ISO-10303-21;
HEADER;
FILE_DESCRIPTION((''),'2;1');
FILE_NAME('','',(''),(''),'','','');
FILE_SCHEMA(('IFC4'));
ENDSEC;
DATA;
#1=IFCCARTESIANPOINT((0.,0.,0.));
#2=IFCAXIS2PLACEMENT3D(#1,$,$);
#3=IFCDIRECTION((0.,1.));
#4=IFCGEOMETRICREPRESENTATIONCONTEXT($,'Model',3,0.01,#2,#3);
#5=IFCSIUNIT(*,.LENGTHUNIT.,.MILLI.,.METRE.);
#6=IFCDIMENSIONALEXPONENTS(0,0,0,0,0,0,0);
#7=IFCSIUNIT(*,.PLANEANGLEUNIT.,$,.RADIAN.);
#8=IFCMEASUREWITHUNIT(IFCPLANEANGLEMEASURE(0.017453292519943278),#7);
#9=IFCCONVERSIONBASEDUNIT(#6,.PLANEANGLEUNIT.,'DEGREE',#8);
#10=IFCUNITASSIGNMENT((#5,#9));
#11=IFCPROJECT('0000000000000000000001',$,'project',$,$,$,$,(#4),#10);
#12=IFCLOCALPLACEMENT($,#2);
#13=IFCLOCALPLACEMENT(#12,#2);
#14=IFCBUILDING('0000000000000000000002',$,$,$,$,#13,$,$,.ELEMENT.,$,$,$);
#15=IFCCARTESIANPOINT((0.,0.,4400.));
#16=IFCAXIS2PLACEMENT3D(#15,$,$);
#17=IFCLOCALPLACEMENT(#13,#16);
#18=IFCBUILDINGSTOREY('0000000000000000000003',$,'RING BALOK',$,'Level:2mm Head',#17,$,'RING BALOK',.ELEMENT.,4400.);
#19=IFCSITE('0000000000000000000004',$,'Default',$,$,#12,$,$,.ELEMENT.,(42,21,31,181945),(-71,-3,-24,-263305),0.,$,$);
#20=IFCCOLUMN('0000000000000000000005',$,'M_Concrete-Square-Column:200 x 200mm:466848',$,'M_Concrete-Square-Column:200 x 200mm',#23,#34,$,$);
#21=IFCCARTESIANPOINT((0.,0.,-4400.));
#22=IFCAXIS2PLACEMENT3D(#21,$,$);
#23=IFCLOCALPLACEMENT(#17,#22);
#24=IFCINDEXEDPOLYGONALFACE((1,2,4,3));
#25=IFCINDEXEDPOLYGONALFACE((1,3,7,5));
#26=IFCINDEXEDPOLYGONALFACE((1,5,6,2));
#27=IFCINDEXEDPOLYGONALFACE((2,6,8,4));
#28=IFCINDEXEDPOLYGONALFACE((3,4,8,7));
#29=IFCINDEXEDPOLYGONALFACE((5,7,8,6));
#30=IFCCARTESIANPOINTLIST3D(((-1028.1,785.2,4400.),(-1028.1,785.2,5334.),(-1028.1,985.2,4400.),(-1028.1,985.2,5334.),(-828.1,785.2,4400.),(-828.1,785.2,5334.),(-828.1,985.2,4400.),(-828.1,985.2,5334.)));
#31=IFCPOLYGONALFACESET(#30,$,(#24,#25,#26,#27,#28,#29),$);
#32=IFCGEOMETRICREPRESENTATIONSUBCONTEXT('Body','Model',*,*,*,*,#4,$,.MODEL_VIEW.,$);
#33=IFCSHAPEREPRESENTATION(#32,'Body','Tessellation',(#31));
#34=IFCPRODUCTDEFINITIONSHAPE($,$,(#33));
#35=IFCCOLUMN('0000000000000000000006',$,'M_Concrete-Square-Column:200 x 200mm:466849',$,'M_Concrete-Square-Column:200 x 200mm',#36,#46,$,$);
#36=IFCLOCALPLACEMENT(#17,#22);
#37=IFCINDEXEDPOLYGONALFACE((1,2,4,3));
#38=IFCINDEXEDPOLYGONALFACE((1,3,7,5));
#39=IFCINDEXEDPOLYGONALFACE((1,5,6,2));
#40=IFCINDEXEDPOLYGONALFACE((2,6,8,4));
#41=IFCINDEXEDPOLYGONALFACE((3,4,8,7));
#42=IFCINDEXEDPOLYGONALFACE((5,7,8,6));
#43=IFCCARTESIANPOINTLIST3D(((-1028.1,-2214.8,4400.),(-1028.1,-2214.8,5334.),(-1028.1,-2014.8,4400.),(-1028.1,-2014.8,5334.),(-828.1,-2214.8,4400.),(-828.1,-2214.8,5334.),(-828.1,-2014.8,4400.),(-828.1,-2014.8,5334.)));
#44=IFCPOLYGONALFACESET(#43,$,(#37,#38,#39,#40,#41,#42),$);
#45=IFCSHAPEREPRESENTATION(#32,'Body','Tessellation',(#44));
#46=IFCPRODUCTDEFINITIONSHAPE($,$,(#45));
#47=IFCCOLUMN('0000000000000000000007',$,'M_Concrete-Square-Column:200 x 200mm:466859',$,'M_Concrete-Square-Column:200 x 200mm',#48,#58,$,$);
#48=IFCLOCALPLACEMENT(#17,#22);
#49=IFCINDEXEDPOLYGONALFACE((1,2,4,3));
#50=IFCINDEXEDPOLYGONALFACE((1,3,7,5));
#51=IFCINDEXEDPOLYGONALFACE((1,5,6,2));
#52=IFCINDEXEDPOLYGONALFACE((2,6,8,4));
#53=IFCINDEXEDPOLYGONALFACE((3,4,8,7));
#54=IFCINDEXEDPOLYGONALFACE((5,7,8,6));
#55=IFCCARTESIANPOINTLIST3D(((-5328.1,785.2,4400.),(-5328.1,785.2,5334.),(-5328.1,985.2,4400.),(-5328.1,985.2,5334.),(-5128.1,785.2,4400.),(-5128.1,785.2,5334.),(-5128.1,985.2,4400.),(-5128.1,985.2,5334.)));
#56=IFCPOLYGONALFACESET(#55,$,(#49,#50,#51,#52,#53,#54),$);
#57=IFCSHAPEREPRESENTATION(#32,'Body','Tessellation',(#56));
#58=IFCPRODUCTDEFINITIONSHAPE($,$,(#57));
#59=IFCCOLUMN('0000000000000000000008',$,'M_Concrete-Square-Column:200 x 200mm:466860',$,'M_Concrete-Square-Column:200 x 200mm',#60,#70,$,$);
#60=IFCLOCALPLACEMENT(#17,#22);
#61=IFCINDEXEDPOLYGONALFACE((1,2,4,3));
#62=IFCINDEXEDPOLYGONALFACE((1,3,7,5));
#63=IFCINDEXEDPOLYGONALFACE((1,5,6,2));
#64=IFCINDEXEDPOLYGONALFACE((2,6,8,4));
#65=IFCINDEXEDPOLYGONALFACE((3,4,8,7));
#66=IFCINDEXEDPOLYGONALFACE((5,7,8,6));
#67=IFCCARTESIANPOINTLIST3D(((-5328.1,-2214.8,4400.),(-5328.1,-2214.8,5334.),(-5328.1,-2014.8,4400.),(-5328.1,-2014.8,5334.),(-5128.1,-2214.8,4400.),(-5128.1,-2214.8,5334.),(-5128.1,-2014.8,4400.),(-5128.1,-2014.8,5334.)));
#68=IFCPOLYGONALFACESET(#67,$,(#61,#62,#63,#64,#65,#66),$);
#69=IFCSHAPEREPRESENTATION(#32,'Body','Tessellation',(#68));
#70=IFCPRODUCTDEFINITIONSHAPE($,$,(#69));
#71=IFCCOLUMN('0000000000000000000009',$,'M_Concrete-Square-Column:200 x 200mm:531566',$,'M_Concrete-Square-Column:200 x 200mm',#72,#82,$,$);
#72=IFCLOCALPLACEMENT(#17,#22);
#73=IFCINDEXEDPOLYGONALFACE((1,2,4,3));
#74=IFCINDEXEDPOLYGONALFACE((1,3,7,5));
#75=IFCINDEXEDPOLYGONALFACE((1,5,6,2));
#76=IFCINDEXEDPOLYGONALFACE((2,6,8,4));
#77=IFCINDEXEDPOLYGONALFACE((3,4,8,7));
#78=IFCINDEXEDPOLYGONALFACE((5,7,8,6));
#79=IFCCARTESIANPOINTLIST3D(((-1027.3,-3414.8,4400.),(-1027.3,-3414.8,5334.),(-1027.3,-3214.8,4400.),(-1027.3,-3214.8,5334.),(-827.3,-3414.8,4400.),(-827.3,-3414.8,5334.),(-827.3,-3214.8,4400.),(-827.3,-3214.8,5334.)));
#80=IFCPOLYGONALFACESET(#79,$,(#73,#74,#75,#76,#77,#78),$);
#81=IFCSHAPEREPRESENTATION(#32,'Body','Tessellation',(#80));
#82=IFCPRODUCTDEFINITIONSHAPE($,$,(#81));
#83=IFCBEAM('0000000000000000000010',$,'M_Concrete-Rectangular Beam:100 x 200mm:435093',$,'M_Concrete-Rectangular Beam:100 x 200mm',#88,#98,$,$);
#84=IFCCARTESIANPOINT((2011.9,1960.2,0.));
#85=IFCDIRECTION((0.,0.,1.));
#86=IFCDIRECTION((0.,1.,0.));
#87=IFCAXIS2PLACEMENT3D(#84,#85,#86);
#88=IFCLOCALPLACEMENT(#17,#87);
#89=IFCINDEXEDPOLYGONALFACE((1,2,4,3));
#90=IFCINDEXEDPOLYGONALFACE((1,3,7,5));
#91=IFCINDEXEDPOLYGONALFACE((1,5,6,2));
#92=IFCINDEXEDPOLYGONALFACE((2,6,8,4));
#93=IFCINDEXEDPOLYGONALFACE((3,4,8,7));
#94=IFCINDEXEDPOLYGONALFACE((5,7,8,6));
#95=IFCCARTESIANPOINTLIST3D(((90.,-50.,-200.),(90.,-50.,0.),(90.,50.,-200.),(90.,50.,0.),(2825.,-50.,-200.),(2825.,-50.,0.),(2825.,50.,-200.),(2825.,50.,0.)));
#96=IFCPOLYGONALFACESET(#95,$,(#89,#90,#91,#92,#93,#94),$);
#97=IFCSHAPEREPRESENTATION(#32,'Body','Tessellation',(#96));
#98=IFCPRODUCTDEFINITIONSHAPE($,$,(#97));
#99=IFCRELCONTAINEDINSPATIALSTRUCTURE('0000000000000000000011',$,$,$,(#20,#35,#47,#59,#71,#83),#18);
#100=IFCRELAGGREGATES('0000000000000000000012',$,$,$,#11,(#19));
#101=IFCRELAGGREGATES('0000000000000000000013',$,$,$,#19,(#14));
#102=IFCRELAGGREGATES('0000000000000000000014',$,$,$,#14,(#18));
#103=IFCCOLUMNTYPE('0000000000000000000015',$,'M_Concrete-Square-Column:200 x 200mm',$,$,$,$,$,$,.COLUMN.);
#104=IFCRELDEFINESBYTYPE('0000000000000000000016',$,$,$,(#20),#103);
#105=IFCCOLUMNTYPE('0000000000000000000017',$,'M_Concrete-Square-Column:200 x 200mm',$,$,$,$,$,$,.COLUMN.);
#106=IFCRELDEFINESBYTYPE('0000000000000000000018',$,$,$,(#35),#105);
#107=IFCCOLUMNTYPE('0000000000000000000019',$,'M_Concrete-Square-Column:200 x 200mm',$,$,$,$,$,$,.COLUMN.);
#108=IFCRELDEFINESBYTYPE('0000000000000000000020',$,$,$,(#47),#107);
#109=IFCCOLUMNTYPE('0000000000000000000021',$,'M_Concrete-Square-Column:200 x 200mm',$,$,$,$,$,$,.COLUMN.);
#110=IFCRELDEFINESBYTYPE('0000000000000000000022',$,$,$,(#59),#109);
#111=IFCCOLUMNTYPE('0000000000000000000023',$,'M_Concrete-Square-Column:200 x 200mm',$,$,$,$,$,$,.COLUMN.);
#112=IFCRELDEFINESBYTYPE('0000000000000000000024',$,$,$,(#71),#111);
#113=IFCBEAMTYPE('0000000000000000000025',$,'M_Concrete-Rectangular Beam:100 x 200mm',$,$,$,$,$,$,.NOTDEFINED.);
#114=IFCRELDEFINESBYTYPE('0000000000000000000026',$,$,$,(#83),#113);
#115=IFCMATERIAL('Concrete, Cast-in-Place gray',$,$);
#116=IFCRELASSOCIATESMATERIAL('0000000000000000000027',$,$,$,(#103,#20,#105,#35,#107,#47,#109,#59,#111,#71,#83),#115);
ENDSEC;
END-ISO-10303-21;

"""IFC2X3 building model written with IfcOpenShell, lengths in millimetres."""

from ifc_helpers import new_model, entity, si_unit, converted_unit, direction, frame, frame_2d, origin, origin_2d_with_axis, place, context, subcontext, project, spatial, rectangle, extrude, source, transform, mapped, material, type_object, type_shapes, element, save


model = new_model("IFC2X3")

# Units and contexts
model_context = context("Model", 3, precision=0.01, world=origin(), true_north=direction((0.0, 1.0)))
body_context = subcontext(model_context, "Body", "Model", "MODEL_VIEW")
ifc_project = project(units=[si_unit("LENGTHUNIT", "METRE", prefix="MILLI"), converted_unit("PLANEANGLEUNIT", "DEGREE", entity("IfcPlaneAngleMeasure", 0.017453292519943278), si_unit("PLANEANGLEUNIT", "RADIAN"), dimensions=[0, 0, 0, 0, 0, 0, 0])], contexts=[model_context])

# Site, building, storey
site_placement = place(None, origin())
site = spatial("IfcSite", under=ifc_project, at=site_placement, Name="Default", CompositionType="ELEMENT", RefLatitude=(42, 21, 31, 181945), RefLongitude=(-71, -3, -24, -263305), RefElevation=0.0)
building_placement = place(site_placement, origin())
building = spatial("IfcBuilding", under=site, at=building_placement, CompositionType="ELEMENT")
storey_placement = place(building_placement, frame((0.0, 0.0, 4400.0)))
storey = spatial("IfcBuildingStorey", under=building, at=storey_placement, Name="RING BALOK", ObjectType="Level:2mm Head", LongName="RING BALOK", CompositionType="ELEMENT", Elevation=4400.0)

# Columns
ifc_material = material(Name="Concrete, Cast-in-Place gray")
column_type_1 = type_object("IfcColumnType", Name="M_Concrete-Square-Column:200 x 200mm", PredefinedType="COLUMN", material=ifc_material)
shared_shape_1 = source(origin(), body_context, "Body", "SweptSolid", [
    extrude(rectangle(XDim=200.0, YDim=200.0, at=origin_2d_with_axis()), frame((-928.1, 885.2, 4400.0), z_axis=(0.0, 0.0, 1.0), x_axis=(-1.0, 0.0, 0.0)), (0.0, 0.0, 1.0), 934.0),
])
type_shapes(column_type_1, [shared_shape_1])
column_1_placement = place(storey_placement, frame((0.0, 0.0, -4400.0)))
element("IfcColumn", 1, at=column_1_placement, inside=storey, type_object=column_type_1, material=ifc_material, Name="M_Concrete-Square-Column:200 x 200mm:466848", ObjectType="M_Concrete-Square-Column:200 x 200mm", context=body_context, shape_type="MappedRepresentation", body=[
    mapped(shared_shape_1, transform((0.0, 0.0, 0.0), scale=1.0)),
])
column_type_2 = type_object("IfcColumnType", Name="M_Concrete-Square-Column:200 x 200mm", PredefinedType="COLUMN", material=ifc_material)
shared_shape_2 = source(origin(), body_context, "Body", "SweptSolid", [
    extrude(rectangle(XDim=200.0, YDim=200.0, at=origin_2d_with_axis()), frame((-928.1, -2114.8, 4400.0), z_axis=(0.0, 0.0, 1.0), x_axis=(-1.0, 0.0, 0.0)), (0.0, 0.0, 1.0), 934.0),
])
type_shapes(column_type_2, [shared_shape_2])
column_2_placement = place(storey_placement, frame((0.0, 0.0, -4400.0)))
element("IfcColumn", 2, at=column_2_placement, inside=storey, type_object=column_type_2, material=ifc_material, Name="M_Concrete-Square-Column:200 x 200mm:466849", ObjectType="M_Concrete-Square-Column:200 x 200mm", context=body_context, shape_type="MappedRepresentation", body=[
    mapped(shared_shape_2, transform((0.0, 0.0, 0.0), scale=1.0)),
])
column_type_3 = type_object("IfcColumnType", Name="M_Concrete-Square-Column:200 x 200mm", PredefinedType="COLUMN", material=ifc_material)
shared_shape_3 = source(origin(), body_context, "Body", "SweptSolid", [
    extrude(rectangle(XDim=200.0, YDim=200.0, at=origin_2d_with_axis()), frame((-5228.1, 885.2, 4400.0), z_axis=(0.0, 0.0, 1.0), x_axis=(-1.0, 0.0, 0.0)), (0.0, 0.0, 1.0), 934.0),
])
type_shapes(column_type_3, [shared_shape_3])
column_3_placement = place(storey_placement, frame((0.0, 0.0, -4400.0)))
element("IfcColumn", 3, at=column_3_placement, inside=storey, type_object=column_type_3, material=ifc_material, Name="M_Concrete-Square-Column:200 x 200mm:466859", ObjectType="M_Concrete-Square-Column:200 x 200mm", context=body_context, shape_type="MappedRepresentation", body=[
    mapped(shared_shape_3, transform((0.0, 0.0, 0.0), scale=1.0)),
])
column_type_4 = type_object("IfcColumnType", Name="M_Concrete-Square-Column:200 x 200mm", PredefinedType="COLUMN", material=ifc_material)
shared_shape_4 = source(origin(), body_context, "Body", "SweptSolid", [
    extrude(rectangle(XDim=200.0, YDim=200.0, at=origin_2d_with_axis()), frame((-5228.1, -2114.8, 4400.0), z_axis=(0.0, 0.0, 1.0), x_axis=(-1.0, 0.0, 0.0)), (0.0, 0.0, 1.0), 934.0),
])
type_shapes(column_type_4, [shared_shape_4])
column_4_placement = place(storey_placement, frame((0.0, 0.0, -4400.0)))
element("IfcColumn", 4, at=column_4_placement, inside=storey, type_object=column_type_4, material=ifc_material, Name="M_Concrete-Square-Column:200 x 200mm:466860", ObjectType="M_Concrete-Square-Column:200 x 200mm", context=body_context, shape_type="MappedRepresentation", body=[
    mapped(shared_shape_4, transform((0.0, 0.0, 0.0), scale=1.0)),
])
column_type_5 = type_object("IfcColumnType", Name="M_Concrete-Square-Column:200 x 200mm", PredefinedType="COLUMN", material=ifc_material)
shared_shape_5 = source(origin(), body_context, "Body", "SweptSolid", [
    extrude(rectangle(XDim=200.0, YDim=200.0, at=frame_2d((0.0, 0.0), x_axis=(1.0, 0.0))), frame((-927.3, -3314.8, 4400.0), z_axis=(0.0, 0.0, 1.0), x_axis=(0.0, -1.0, 0.0)), (0.0, 0.0, 1.0), 934.0),
])
type_shapes(column_type_5, [shared_shape_5])
column_5_placement = place(storey_placement, frame((0.0, 0.0, -4400.0)))
element("IfcColumn", 5, at=column_5_placement, inside=storey, type_object=column_type_5, material=ifc_material, Name="M_Concrete-Square-Column:200 x 200mm:531566", ObjectType="M_Concrete-Square-Column:200 x 200mm", context=body_context, shape_type="MappedRepresentation", body=[
    mapped(shared_shape_5, transform((0.0, 0.0, 0.0), scale=1.0)),
])

# Beam
beam_type_1 = type_object("IfcBeamType", Name="M_Concrete-Rectangular Beam:100 x 200mm", PredefinedType="NOTDEFINED")
beam_1_placement = place(storey_placement, frame((2011.9, 1960.2, 0.0), z_axis=(0.0, 0.0, 1.0), x_axis=(0.0, 1.0, 0.0)))
element("IfcBeam", 6, at=beam_1_placement, inside=storey, type_object=beam_type_1, material=ifc_material, Name="M_Concrete-Rectangular Beam:100 x 200mm:435093", ObjectType="M_Concrete-Rectangular Beam:100 x 200mm", context=body_context, shape_type="SweptSolid", body=[
    extrude(rectangle(XDim=200.0, YDim=100.0, at=frame_2d((0.0, 0.0), x_axis=(1.0, 0.0))), frame((90.0, 0.0, -100.0), z_axis=(1.0, 0.0, 0.0), x_axis=(0.0, 0.0, -1.0)), (0.0, 0.0, 1.0), 2735.0),
])

save(model, "model.ifc")
